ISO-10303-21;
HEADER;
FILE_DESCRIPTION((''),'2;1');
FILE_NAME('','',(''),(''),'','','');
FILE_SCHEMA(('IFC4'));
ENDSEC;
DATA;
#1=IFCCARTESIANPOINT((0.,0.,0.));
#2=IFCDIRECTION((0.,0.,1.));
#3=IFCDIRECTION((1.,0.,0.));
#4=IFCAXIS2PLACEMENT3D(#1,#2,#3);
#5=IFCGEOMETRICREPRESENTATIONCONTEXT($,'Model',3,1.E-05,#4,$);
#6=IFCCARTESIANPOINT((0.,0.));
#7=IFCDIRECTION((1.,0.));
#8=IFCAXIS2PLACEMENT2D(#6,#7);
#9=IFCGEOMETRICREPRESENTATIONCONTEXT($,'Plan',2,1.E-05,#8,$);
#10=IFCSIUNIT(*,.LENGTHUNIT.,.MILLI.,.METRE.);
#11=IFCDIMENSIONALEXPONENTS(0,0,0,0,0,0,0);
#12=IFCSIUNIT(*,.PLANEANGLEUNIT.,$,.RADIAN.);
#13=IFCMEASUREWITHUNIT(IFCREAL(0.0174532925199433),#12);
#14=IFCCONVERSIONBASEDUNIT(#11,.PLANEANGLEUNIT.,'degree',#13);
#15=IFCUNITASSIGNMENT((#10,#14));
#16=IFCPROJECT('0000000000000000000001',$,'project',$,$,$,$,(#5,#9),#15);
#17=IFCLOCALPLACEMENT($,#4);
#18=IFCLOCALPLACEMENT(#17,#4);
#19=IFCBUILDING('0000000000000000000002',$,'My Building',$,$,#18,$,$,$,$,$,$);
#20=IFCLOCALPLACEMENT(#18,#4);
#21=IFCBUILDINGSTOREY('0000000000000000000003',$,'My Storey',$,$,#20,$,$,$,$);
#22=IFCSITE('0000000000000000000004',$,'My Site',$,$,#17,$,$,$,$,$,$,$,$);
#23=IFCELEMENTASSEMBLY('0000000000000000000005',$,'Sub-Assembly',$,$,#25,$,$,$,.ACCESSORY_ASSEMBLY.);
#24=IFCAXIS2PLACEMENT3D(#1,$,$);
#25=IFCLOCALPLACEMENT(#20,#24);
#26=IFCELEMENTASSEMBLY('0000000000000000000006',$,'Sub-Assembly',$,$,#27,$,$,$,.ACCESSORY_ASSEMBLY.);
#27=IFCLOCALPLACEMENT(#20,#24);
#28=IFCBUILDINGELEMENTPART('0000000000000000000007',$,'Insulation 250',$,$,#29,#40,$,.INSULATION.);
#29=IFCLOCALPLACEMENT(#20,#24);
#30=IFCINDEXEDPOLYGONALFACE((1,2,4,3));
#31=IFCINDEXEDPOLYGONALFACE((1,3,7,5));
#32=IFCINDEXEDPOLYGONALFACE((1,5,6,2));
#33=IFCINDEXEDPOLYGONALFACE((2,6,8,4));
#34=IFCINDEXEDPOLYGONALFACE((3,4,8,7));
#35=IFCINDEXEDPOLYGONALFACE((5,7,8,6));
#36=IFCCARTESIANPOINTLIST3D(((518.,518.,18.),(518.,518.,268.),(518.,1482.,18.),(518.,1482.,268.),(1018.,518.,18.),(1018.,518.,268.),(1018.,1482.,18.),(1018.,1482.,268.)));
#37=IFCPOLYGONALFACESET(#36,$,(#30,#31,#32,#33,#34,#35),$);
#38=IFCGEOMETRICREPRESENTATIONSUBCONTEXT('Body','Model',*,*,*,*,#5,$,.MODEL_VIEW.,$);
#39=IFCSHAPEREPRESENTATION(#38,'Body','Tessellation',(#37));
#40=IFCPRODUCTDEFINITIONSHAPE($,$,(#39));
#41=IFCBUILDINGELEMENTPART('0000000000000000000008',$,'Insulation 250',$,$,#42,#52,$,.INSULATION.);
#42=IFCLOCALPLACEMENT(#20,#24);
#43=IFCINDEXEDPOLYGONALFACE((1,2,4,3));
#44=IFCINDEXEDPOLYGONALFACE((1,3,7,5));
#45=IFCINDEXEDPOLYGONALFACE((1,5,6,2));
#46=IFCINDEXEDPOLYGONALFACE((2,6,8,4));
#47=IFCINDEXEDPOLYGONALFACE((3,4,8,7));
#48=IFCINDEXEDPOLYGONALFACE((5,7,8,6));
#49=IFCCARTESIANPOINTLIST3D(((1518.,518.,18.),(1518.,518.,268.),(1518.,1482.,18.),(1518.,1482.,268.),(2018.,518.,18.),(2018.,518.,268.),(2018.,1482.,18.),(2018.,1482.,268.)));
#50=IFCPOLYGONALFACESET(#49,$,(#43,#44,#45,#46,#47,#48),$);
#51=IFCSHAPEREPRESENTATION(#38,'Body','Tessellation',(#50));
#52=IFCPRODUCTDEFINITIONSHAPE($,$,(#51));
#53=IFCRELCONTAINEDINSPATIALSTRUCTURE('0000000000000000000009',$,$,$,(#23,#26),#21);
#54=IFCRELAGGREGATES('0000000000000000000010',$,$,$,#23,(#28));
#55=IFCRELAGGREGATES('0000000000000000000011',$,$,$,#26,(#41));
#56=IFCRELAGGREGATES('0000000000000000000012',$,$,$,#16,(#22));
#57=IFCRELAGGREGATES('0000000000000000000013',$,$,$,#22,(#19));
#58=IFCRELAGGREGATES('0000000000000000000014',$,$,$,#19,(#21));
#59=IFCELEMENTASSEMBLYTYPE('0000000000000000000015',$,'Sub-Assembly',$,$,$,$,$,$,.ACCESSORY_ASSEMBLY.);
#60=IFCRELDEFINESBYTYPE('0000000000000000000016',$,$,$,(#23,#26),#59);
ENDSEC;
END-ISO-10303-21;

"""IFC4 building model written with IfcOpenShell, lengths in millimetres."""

from ifc_helpers import new_model, entity, si_unit, converted_unit, frame, origin_with_axes, origin_2d_with_axis, place, context, subcontext, project, spatial, rectangle, extrude, type_object, element, aggregate, save


model = new_model("IFC4")

# Units and contexts
model_context = context("Model", 3, precision=1e-05, world=origin_with_axes())
plan_context = context("Plan", 2, precision=1e-05, world=origin_2d_with_axis())
body_context = subcontext(model_context, "Body", "Model", "MODEL_VIEW")
ifc_project = project(units=[si_unit("LENGTHUNIT", "METRE", prefix="MILLI"), converted_unit("PLANEANGLEUNIT", "degree", entity("IfcReal", 0.0174532925199433), si_unit("PLANEANGLEUNIT", "RADIAN"), dimensions=[0, 0, 0, 0, 0, 0, 0])], contexts=[model_context, plan_context])

# Site, building, storey
site_placement = place(None, origin_with_axes())
site = spatial("IfcSite", under=ifc_project, at=site_placement, Name="My Site")
building_placement = place(site_placement, origin_with_axes())
building = spatial("IfcBuilding", under=site, at=building_placement, Name="My Building")
storey_placement = place(building_placement, origin_with_axes())
storey = spatial("IfcBuildingStorey", under=building, at=storey_placement, Name="My Storey")

# Element assemblies
element_assembly_type_1 = type_object("IfcElementAssemblyType", Name="Sub-Assembly", PredefinedType="ACCESSORY_ASSEMBLY")
assembly_1_placement = place(storey_placement, frame((500.0, 500.0, 0.0)))
assembly_1 = element("IfcElementAssembly", 1, at=assembly_1_placement, inside=storey, type_object=element_assembly_type_1, Name="Sub-Assembly", PredefinedType="ACCESSORY_ASSEMBLY")
assembly_2_placement = place(storey_placement, frame((1500.0, 500.0, 0.0)))
assembly_2 = element("IfcElementAssembly", 2, at=assembly_2_placement, inside=storey, type_object=element_assembly_type_1, Name="Sub-Assembly", PredefinedType="ACCESSORY_ASSEMBLY")

# Building element parts
building_element_part_1_placement = place(assembly_1_placement, frame((268.0, 500.0, 18.0), z_axis=(0.0, 0.0, 1.0), x_axis=(1.0, 0.0, 0.0)))
building_element_part_1 = element("IfcBuildingElementPart", 3, at=building_element_part_1_placement, Name="Insulation 250", PredefinedType="INSULATION", context=body_context, shape_type="SweptSolid", body=[
    extrude(rectangle(XDim=500.0, YDim=964.0), None, (0.0, 0.0, 1.0), 250.0),
])
aggregate(assembly_1, [building_element_part_1])
building_element_part_2_placement = place(assembly_2_placement, frame((268.0, 500.0, 18.0), z_axis=(0.0, 0.0, 1.0), x_axis=(1.0, 0.0, 0.0)))
building_element_part_2 = element("IfcBuildingElementPart", 4, at=building_element_part_2_placement, Name="Insulation 250", PredefinedType="INSULATION", context=body_context, shape_type="SweptSolid", body=[
    extrude(rectangle(XDim=500.0, YDim=964.0), None, (0.0, 0.0, 1.0), 250.0),
])
aggregate(assembly_2, [building_element_part_2])

save(model, "model.ifc")
